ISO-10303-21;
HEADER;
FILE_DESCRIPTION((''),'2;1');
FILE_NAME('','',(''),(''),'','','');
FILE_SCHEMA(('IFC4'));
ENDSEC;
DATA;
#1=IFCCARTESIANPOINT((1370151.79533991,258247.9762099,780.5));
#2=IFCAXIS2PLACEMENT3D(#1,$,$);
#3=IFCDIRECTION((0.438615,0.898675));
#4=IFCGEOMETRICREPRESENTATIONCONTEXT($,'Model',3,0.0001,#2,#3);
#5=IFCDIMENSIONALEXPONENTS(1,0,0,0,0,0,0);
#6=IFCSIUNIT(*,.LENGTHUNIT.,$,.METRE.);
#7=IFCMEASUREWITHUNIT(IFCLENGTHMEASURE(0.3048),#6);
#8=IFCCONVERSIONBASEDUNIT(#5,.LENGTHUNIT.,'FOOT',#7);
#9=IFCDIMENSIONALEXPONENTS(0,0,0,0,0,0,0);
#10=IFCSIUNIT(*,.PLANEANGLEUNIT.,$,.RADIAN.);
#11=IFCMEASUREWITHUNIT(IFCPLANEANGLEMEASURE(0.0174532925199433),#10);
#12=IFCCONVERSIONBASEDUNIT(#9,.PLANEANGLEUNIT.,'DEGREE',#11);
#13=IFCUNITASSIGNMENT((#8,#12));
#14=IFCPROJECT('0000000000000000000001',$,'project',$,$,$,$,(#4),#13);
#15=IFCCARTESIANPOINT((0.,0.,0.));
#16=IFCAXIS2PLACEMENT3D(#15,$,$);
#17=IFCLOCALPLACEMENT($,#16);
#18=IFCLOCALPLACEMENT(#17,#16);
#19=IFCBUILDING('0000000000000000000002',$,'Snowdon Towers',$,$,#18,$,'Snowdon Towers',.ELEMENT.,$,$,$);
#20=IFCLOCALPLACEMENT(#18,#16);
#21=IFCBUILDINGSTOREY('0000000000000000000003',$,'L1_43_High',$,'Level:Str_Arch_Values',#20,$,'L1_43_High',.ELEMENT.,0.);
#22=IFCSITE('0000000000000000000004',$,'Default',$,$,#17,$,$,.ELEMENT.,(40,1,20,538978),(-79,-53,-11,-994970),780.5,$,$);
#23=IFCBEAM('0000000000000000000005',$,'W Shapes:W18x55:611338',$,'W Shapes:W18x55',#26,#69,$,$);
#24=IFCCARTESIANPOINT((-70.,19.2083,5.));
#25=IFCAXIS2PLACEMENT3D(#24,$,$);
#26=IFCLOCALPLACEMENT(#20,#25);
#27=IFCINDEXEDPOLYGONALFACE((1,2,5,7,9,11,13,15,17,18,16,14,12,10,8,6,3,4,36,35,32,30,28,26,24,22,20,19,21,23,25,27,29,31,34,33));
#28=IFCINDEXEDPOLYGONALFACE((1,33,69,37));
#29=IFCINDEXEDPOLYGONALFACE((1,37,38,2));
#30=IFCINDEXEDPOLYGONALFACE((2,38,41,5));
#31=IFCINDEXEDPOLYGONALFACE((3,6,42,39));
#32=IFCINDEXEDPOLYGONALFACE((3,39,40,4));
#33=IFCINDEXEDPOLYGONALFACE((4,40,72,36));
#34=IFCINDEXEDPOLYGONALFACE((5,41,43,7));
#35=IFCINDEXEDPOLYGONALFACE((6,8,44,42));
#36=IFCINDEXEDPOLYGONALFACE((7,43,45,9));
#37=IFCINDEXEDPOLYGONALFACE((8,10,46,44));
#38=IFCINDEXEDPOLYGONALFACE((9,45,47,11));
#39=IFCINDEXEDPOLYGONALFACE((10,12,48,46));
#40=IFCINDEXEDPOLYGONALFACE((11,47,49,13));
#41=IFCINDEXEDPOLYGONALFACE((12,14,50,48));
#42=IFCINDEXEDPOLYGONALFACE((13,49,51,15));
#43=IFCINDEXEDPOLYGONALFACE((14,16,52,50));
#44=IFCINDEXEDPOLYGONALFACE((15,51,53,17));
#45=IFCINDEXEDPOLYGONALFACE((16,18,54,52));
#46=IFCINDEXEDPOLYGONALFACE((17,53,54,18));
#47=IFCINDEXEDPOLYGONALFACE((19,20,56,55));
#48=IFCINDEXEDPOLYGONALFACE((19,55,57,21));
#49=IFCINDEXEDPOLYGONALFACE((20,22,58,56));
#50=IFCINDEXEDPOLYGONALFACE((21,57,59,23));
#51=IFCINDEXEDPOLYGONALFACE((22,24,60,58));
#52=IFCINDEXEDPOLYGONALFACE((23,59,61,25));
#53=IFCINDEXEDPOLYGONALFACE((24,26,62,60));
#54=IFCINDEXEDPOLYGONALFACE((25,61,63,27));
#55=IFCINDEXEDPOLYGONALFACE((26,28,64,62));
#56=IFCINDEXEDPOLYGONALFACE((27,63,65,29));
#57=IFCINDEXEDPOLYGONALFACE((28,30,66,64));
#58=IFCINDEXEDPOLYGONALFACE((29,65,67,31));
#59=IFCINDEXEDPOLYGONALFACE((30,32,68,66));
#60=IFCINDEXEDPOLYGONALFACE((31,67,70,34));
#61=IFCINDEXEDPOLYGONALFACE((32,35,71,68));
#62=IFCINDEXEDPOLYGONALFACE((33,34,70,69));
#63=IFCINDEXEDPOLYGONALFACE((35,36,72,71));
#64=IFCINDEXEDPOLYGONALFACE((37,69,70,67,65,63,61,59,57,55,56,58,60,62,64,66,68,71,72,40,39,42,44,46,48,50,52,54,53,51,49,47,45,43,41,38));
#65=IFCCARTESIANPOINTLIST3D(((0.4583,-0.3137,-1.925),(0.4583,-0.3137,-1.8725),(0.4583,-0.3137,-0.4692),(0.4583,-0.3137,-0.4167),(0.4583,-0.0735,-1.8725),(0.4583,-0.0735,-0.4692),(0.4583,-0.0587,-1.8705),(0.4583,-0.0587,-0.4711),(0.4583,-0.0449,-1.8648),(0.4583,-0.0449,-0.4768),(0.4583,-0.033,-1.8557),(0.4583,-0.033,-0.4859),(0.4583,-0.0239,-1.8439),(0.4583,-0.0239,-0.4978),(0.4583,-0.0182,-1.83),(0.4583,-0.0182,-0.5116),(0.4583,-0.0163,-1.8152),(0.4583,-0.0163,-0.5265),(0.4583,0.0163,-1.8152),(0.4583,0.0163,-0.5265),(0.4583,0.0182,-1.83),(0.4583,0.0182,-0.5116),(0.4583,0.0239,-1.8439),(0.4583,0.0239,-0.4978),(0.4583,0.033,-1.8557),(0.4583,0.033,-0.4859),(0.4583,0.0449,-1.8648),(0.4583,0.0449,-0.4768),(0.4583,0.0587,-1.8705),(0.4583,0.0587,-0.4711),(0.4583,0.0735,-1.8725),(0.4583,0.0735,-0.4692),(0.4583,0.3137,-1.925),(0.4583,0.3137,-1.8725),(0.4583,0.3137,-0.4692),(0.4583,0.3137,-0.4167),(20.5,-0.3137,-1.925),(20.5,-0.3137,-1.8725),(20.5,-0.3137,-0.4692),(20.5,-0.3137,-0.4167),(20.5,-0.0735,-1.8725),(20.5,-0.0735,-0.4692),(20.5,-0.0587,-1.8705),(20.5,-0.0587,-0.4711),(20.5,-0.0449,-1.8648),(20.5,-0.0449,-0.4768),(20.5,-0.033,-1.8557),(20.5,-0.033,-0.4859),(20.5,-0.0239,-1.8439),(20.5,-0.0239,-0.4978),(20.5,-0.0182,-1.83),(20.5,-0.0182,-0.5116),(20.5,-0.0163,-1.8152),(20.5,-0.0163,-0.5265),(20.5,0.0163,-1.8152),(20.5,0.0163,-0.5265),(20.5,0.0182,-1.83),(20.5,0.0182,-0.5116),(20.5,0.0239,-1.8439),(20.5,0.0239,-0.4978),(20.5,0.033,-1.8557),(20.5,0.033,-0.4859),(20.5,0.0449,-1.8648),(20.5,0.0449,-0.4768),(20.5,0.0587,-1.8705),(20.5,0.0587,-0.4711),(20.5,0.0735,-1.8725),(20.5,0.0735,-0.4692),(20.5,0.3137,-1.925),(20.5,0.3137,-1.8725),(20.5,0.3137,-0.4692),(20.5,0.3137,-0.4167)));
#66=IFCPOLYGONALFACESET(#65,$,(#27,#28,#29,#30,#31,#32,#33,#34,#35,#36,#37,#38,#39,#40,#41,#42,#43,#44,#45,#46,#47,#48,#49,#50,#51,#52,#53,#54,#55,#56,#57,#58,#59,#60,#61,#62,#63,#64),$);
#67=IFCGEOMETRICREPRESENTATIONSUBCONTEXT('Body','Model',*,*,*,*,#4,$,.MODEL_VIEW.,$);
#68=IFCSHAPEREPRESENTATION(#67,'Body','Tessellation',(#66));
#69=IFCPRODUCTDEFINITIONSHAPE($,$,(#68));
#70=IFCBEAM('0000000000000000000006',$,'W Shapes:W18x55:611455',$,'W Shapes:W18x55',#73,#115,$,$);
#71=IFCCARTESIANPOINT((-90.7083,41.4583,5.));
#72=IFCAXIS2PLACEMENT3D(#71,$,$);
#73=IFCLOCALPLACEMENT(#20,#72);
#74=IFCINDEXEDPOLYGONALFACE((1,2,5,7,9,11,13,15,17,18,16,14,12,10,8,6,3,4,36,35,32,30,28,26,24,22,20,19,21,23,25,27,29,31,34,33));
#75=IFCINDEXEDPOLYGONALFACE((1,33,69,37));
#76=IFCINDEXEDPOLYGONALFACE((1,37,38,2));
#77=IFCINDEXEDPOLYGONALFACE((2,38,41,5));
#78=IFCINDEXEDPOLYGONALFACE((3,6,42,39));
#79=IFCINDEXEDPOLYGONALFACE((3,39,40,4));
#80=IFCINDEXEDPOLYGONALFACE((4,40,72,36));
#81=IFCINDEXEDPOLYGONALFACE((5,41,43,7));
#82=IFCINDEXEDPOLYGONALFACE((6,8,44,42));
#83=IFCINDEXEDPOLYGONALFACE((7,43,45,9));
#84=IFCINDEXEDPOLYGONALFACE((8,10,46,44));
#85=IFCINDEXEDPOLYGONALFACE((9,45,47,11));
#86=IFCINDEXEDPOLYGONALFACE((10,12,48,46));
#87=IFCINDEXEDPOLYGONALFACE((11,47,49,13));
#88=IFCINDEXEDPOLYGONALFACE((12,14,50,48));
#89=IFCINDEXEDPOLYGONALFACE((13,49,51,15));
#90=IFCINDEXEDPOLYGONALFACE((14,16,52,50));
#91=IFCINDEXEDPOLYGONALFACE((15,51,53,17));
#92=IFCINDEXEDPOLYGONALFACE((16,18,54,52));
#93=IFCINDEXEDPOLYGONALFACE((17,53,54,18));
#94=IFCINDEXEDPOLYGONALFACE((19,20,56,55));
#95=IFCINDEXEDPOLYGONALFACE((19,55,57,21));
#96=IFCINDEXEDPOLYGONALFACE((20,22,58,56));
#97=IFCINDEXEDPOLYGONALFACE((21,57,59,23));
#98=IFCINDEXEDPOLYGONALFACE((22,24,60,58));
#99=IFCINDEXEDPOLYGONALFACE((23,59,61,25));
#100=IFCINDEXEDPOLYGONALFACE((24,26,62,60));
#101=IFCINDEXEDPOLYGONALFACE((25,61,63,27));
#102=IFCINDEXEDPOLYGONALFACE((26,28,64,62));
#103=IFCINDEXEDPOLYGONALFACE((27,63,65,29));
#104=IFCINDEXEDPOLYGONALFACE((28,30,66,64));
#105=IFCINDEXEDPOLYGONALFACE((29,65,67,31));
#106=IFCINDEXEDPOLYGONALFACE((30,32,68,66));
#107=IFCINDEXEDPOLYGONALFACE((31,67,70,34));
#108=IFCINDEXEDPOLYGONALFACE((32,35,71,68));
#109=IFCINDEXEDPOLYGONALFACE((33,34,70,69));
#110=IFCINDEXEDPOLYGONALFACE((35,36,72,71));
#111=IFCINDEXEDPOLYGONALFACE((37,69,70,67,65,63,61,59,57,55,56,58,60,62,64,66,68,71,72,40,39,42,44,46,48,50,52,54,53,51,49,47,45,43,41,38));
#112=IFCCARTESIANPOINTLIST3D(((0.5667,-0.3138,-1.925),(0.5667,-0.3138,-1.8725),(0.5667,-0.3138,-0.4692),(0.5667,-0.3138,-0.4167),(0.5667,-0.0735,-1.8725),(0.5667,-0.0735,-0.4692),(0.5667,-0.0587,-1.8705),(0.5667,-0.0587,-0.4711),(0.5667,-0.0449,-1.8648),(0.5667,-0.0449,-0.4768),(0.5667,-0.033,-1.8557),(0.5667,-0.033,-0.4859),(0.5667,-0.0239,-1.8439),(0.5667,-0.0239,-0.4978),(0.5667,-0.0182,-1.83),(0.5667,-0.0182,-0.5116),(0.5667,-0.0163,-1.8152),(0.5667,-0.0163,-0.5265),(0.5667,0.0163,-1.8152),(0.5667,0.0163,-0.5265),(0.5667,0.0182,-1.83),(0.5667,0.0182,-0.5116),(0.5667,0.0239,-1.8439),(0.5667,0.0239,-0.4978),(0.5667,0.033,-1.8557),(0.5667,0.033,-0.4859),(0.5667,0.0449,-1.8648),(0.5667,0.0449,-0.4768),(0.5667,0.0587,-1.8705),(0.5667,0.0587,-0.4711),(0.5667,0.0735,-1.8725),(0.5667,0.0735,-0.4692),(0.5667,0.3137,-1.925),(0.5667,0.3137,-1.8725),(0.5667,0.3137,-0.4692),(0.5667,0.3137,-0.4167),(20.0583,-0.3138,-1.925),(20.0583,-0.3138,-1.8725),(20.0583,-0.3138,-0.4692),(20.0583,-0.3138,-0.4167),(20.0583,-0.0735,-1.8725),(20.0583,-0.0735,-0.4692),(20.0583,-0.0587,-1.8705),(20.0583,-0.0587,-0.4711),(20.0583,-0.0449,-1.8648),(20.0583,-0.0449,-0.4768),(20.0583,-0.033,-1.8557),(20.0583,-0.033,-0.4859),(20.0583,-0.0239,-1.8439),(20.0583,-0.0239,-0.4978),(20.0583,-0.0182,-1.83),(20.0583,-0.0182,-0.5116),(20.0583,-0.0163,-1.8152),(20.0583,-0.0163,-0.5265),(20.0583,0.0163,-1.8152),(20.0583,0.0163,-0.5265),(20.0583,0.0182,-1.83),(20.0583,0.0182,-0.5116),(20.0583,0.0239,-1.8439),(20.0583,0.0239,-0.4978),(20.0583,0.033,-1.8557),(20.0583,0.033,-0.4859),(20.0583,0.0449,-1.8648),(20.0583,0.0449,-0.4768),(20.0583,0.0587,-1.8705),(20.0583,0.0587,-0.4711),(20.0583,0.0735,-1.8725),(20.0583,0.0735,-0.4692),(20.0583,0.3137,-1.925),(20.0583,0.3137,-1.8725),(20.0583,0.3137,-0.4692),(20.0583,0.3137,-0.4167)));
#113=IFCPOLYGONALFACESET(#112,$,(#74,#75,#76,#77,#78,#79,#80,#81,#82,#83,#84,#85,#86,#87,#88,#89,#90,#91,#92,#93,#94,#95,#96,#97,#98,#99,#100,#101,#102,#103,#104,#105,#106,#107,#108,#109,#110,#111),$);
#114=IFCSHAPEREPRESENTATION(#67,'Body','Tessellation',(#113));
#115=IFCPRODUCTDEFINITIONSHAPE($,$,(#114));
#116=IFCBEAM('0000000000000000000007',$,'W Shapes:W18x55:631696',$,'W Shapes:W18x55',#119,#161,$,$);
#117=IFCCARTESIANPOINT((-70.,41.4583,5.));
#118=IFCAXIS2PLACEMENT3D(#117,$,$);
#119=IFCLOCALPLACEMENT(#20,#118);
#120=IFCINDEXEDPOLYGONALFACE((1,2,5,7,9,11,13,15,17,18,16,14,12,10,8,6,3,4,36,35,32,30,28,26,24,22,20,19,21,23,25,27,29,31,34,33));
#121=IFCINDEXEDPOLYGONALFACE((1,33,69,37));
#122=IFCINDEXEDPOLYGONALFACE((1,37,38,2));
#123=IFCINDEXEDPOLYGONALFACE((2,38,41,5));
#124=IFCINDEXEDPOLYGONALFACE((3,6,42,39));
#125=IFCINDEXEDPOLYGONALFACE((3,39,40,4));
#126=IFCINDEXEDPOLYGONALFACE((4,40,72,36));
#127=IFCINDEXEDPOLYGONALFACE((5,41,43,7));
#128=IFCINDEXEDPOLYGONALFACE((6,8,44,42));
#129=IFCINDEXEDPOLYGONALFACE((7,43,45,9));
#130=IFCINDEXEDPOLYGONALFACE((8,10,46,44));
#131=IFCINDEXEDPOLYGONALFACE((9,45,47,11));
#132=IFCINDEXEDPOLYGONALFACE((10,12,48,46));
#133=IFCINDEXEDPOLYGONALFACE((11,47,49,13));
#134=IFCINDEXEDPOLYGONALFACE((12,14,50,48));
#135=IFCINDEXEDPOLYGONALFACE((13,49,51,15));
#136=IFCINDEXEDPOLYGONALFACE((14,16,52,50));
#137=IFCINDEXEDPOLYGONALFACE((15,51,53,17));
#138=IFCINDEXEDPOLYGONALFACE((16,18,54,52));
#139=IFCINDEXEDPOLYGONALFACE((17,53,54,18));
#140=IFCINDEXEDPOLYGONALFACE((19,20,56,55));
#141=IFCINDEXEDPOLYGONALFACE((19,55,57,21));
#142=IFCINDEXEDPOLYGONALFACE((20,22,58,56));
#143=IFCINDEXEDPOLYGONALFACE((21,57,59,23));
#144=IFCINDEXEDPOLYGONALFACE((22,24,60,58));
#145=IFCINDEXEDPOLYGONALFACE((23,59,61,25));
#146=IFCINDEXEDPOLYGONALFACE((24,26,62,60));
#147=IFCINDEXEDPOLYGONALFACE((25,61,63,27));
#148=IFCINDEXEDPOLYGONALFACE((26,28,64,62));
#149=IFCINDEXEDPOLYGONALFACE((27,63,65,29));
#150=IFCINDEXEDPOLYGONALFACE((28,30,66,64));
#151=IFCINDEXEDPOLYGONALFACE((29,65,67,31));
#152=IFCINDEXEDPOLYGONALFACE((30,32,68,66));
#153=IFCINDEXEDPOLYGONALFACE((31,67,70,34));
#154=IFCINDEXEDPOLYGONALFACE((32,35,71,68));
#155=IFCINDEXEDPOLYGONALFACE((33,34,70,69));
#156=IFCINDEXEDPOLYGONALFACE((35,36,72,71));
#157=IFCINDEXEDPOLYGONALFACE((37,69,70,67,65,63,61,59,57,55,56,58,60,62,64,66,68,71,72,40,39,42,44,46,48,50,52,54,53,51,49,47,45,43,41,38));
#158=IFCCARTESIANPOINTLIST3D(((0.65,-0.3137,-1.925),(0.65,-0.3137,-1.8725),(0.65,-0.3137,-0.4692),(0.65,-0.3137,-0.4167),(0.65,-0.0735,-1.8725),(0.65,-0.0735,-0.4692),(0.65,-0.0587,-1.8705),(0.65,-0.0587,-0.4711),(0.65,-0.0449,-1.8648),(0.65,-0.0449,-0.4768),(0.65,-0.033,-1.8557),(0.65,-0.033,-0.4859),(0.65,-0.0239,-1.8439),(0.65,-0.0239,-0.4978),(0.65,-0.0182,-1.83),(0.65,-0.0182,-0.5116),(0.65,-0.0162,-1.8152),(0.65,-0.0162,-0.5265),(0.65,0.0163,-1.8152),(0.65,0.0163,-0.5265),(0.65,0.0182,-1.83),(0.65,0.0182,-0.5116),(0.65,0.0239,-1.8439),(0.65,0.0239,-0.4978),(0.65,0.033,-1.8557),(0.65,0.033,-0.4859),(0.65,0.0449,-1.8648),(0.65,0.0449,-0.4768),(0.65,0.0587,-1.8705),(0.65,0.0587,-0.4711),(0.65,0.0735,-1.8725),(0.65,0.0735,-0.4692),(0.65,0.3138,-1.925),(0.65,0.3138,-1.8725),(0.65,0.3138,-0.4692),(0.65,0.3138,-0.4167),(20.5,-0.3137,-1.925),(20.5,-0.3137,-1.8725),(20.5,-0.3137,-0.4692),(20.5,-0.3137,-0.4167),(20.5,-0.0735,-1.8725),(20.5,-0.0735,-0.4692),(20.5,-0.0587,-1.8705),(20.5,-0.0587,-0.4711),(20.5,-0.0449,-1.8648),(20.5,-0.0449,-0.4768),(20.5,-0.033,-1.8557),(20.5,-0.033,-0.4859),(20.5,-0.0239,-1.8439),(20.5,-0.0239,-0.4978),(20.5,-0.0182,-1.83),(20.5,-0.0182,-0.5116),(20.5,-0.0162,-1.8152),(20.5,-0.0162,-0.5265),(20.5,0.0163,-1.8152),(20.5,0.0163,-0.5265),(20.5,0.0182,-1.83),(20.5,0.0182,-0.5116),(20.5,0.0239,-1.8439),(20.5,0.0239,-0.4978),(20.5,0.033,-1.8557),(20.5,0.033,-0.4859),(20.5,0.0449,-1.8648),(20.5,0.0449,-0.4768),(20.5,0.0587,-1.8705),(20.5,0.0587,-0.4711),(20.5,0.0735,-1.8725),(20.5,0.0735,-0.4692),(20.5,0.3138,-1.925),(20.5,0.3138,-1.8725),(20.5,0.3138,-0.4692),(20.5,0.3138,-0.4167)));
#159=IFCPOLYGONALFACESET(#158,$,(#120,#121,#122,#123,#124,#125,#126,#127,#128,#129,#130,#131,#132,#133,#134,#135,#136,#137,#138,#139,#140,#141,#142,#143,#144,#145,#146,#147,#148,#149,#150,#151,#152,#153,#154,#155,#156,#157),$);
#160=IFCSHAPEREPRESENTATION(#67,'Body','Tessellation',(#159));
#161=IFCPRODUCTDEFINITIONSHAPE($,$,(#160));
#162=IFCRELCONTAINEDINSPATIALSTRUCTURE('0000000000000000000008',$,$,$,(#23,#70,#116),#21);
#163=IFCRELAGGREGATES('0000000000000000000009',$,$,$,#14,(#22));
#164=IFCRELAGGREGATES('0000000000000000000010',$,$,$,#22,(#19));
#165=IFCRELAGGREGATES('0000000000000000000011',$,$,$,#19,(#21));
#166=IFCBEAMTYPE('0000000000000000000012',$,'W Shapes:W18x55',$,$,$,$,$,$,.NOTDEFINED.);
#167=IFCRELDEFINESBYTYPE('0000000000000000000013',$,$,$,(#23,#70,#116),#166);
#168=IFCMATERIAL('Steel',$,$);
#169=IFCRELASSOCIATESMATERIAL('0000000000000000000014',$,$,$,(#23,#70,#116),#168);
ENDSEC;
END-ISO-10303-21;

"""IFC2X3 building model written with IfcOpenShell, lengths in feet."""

from ifc_helpers import new_model, entity, si_unit, converted_unit, direction, frame, frame_2d, origin, place, context, subcontext, project, spatial, i_section, extrude, material, type_object, element, save


model = new_model("IFC2X3")

# Units and contexts
model_context = context("Model", 3, precision=0.0001, world=frame((1370151.79533991, 258247.9762099, 780.5)), true_north=direction((0.438615, 0.898675)))
body_context = subcontext(model_context, "Body", "Model", "MODEL_VIEW")
ifc_project = project(units=[converted_unit("LENGTHUNIT", "FOOT", entity("IfcLengthMeasure", 0.3048), si_unit("LENGTHUNIT", "METRE"), dimensions=[1, 0, 0, 0, 0, 0, 0]), converted_unit("PLANEANGLEUNIT", "DEGREE", entity("IfcPlaneAngleMeasure", 0.0174532925199433), si_unit("PLANEANGLEUNIT", "RADIAN"), dimensions=[0, 0, 0, 0, 0, 0, 0])], contexts=[model_context])

# Site, building, storey
site_placement = place(None, origin())
site = spatial("IfcSite", under=ifc_project, at=site_placement, Name="Default", CompositionType="ELEMENT", RefLatitude=(40, 1, 20, 538978), RefLongitude=(-79, -53, -11, -994970), RefElevation=780.5)
building_placement = place(site_placement, origin())
building = spatial("IfcBuilding", under=site, at=building_placement, Name="Snowdon Towers", LongName="Snowdon Towers", CompositionType="ELEMENT")
storey_placement = place(building_placement, origin())
storey = spatial("IfcBuildingStorey", under=building, at=storey_placement, Name="L1_43_High", ObjectType="Level:Str_Arch_Values", LongName="L1_43_High", CompositionType="ELEMENT", Elevation=0.0)

# Beams
ifc_material_1 = material(Name="Steel")
beam_type = type_object("IfcBeamType", Name="W Shapes:W18x55", PredefinedType="NOTDEFINED")
beam_1_placement = place(storey_placement, frame((-70.0, 19.2083, 5.0)))
element("IfcBeam", 1, at=beam_1_placement, inside=storey, type_object=beam_type, material=ifc_material_1, Name="W Shapes:W18x55:611338", ObjectType="W Shapes:W18x55", context=body_context, shape_type="SweptSolid", body=[
    extrude(i_section(OverallWidth=0.6275, OverallDepth=1.5083, WebThickness=0.0325, FlangeThickness=0.0525, FilletRadius=0.0573, at=frame_2d((0.0, 0.0), x_axis=(0.0, 1.0))), frame((0.4583, 0.0, -1.1708), z_axis=(1.0, 0.0, 0.0), x_axis=(0.0, 0.0, -1.0)), (0.0, 0.0, 1.0), 20.0417),
])
beam_2_placement = place(storey_placement, frame((-90.7083, 41.4583, 5.0)))
element("IfcBeam", 2, at=beam_2_placement, inside=storey, type_object=beam_type, material=ifc_material_1, Name="W Shapes:W18x55:611455", ObjectType="W Shapes:W18x55", context=body_context, shape_type="SweptSolid", body=[
    extrude(i_section(OverallWidth=0.6275, OverallDepth=1.5083, WebThickness=0.0325, FlangeThickness=0.0525, FilletRadius=0.0573, at=frame_2d((0.0, 0.0), x_axis=(0.0, 1.0))), frame((0.5667, 0.0, -1.1708), z_axis=(1.0, 0.0, 0.0), x_axis=(0.0, 0.0, -1.0)), (0.0, 0.0, 1.0), 19.4917),
])
beam_3_placement = place(storey_placement, frame((-70.0, 41.4583, 5.0)))
element("IfcBeam", 3, at=beam_3_placement, inside=storey, type_object=beam_type, material=ifc_material_1, Name="W Shapes:W18x55:631696", ObjectType="W Shapes:W18x55", context=body_context, shape_type="SweptSolid", body=[
    extrude(i_section(OverallWidth=0.6275, OverallDepth=1.5083, WebThickness=0.0325, FlangeThickness=0.0525, FilletRadius=0.0573, at=frame_2d((0.0, 0.0), x_axis=(0.0, 1.0))), frame((0.65, 0.0, -1.1708), z_axis=(1.0, 0.0, 0.0), x_axis=(0.0, 0.0, -1.0)), (0.0, 0.0, 1.0), 19.85),
])

save(model, "model.ifc")
